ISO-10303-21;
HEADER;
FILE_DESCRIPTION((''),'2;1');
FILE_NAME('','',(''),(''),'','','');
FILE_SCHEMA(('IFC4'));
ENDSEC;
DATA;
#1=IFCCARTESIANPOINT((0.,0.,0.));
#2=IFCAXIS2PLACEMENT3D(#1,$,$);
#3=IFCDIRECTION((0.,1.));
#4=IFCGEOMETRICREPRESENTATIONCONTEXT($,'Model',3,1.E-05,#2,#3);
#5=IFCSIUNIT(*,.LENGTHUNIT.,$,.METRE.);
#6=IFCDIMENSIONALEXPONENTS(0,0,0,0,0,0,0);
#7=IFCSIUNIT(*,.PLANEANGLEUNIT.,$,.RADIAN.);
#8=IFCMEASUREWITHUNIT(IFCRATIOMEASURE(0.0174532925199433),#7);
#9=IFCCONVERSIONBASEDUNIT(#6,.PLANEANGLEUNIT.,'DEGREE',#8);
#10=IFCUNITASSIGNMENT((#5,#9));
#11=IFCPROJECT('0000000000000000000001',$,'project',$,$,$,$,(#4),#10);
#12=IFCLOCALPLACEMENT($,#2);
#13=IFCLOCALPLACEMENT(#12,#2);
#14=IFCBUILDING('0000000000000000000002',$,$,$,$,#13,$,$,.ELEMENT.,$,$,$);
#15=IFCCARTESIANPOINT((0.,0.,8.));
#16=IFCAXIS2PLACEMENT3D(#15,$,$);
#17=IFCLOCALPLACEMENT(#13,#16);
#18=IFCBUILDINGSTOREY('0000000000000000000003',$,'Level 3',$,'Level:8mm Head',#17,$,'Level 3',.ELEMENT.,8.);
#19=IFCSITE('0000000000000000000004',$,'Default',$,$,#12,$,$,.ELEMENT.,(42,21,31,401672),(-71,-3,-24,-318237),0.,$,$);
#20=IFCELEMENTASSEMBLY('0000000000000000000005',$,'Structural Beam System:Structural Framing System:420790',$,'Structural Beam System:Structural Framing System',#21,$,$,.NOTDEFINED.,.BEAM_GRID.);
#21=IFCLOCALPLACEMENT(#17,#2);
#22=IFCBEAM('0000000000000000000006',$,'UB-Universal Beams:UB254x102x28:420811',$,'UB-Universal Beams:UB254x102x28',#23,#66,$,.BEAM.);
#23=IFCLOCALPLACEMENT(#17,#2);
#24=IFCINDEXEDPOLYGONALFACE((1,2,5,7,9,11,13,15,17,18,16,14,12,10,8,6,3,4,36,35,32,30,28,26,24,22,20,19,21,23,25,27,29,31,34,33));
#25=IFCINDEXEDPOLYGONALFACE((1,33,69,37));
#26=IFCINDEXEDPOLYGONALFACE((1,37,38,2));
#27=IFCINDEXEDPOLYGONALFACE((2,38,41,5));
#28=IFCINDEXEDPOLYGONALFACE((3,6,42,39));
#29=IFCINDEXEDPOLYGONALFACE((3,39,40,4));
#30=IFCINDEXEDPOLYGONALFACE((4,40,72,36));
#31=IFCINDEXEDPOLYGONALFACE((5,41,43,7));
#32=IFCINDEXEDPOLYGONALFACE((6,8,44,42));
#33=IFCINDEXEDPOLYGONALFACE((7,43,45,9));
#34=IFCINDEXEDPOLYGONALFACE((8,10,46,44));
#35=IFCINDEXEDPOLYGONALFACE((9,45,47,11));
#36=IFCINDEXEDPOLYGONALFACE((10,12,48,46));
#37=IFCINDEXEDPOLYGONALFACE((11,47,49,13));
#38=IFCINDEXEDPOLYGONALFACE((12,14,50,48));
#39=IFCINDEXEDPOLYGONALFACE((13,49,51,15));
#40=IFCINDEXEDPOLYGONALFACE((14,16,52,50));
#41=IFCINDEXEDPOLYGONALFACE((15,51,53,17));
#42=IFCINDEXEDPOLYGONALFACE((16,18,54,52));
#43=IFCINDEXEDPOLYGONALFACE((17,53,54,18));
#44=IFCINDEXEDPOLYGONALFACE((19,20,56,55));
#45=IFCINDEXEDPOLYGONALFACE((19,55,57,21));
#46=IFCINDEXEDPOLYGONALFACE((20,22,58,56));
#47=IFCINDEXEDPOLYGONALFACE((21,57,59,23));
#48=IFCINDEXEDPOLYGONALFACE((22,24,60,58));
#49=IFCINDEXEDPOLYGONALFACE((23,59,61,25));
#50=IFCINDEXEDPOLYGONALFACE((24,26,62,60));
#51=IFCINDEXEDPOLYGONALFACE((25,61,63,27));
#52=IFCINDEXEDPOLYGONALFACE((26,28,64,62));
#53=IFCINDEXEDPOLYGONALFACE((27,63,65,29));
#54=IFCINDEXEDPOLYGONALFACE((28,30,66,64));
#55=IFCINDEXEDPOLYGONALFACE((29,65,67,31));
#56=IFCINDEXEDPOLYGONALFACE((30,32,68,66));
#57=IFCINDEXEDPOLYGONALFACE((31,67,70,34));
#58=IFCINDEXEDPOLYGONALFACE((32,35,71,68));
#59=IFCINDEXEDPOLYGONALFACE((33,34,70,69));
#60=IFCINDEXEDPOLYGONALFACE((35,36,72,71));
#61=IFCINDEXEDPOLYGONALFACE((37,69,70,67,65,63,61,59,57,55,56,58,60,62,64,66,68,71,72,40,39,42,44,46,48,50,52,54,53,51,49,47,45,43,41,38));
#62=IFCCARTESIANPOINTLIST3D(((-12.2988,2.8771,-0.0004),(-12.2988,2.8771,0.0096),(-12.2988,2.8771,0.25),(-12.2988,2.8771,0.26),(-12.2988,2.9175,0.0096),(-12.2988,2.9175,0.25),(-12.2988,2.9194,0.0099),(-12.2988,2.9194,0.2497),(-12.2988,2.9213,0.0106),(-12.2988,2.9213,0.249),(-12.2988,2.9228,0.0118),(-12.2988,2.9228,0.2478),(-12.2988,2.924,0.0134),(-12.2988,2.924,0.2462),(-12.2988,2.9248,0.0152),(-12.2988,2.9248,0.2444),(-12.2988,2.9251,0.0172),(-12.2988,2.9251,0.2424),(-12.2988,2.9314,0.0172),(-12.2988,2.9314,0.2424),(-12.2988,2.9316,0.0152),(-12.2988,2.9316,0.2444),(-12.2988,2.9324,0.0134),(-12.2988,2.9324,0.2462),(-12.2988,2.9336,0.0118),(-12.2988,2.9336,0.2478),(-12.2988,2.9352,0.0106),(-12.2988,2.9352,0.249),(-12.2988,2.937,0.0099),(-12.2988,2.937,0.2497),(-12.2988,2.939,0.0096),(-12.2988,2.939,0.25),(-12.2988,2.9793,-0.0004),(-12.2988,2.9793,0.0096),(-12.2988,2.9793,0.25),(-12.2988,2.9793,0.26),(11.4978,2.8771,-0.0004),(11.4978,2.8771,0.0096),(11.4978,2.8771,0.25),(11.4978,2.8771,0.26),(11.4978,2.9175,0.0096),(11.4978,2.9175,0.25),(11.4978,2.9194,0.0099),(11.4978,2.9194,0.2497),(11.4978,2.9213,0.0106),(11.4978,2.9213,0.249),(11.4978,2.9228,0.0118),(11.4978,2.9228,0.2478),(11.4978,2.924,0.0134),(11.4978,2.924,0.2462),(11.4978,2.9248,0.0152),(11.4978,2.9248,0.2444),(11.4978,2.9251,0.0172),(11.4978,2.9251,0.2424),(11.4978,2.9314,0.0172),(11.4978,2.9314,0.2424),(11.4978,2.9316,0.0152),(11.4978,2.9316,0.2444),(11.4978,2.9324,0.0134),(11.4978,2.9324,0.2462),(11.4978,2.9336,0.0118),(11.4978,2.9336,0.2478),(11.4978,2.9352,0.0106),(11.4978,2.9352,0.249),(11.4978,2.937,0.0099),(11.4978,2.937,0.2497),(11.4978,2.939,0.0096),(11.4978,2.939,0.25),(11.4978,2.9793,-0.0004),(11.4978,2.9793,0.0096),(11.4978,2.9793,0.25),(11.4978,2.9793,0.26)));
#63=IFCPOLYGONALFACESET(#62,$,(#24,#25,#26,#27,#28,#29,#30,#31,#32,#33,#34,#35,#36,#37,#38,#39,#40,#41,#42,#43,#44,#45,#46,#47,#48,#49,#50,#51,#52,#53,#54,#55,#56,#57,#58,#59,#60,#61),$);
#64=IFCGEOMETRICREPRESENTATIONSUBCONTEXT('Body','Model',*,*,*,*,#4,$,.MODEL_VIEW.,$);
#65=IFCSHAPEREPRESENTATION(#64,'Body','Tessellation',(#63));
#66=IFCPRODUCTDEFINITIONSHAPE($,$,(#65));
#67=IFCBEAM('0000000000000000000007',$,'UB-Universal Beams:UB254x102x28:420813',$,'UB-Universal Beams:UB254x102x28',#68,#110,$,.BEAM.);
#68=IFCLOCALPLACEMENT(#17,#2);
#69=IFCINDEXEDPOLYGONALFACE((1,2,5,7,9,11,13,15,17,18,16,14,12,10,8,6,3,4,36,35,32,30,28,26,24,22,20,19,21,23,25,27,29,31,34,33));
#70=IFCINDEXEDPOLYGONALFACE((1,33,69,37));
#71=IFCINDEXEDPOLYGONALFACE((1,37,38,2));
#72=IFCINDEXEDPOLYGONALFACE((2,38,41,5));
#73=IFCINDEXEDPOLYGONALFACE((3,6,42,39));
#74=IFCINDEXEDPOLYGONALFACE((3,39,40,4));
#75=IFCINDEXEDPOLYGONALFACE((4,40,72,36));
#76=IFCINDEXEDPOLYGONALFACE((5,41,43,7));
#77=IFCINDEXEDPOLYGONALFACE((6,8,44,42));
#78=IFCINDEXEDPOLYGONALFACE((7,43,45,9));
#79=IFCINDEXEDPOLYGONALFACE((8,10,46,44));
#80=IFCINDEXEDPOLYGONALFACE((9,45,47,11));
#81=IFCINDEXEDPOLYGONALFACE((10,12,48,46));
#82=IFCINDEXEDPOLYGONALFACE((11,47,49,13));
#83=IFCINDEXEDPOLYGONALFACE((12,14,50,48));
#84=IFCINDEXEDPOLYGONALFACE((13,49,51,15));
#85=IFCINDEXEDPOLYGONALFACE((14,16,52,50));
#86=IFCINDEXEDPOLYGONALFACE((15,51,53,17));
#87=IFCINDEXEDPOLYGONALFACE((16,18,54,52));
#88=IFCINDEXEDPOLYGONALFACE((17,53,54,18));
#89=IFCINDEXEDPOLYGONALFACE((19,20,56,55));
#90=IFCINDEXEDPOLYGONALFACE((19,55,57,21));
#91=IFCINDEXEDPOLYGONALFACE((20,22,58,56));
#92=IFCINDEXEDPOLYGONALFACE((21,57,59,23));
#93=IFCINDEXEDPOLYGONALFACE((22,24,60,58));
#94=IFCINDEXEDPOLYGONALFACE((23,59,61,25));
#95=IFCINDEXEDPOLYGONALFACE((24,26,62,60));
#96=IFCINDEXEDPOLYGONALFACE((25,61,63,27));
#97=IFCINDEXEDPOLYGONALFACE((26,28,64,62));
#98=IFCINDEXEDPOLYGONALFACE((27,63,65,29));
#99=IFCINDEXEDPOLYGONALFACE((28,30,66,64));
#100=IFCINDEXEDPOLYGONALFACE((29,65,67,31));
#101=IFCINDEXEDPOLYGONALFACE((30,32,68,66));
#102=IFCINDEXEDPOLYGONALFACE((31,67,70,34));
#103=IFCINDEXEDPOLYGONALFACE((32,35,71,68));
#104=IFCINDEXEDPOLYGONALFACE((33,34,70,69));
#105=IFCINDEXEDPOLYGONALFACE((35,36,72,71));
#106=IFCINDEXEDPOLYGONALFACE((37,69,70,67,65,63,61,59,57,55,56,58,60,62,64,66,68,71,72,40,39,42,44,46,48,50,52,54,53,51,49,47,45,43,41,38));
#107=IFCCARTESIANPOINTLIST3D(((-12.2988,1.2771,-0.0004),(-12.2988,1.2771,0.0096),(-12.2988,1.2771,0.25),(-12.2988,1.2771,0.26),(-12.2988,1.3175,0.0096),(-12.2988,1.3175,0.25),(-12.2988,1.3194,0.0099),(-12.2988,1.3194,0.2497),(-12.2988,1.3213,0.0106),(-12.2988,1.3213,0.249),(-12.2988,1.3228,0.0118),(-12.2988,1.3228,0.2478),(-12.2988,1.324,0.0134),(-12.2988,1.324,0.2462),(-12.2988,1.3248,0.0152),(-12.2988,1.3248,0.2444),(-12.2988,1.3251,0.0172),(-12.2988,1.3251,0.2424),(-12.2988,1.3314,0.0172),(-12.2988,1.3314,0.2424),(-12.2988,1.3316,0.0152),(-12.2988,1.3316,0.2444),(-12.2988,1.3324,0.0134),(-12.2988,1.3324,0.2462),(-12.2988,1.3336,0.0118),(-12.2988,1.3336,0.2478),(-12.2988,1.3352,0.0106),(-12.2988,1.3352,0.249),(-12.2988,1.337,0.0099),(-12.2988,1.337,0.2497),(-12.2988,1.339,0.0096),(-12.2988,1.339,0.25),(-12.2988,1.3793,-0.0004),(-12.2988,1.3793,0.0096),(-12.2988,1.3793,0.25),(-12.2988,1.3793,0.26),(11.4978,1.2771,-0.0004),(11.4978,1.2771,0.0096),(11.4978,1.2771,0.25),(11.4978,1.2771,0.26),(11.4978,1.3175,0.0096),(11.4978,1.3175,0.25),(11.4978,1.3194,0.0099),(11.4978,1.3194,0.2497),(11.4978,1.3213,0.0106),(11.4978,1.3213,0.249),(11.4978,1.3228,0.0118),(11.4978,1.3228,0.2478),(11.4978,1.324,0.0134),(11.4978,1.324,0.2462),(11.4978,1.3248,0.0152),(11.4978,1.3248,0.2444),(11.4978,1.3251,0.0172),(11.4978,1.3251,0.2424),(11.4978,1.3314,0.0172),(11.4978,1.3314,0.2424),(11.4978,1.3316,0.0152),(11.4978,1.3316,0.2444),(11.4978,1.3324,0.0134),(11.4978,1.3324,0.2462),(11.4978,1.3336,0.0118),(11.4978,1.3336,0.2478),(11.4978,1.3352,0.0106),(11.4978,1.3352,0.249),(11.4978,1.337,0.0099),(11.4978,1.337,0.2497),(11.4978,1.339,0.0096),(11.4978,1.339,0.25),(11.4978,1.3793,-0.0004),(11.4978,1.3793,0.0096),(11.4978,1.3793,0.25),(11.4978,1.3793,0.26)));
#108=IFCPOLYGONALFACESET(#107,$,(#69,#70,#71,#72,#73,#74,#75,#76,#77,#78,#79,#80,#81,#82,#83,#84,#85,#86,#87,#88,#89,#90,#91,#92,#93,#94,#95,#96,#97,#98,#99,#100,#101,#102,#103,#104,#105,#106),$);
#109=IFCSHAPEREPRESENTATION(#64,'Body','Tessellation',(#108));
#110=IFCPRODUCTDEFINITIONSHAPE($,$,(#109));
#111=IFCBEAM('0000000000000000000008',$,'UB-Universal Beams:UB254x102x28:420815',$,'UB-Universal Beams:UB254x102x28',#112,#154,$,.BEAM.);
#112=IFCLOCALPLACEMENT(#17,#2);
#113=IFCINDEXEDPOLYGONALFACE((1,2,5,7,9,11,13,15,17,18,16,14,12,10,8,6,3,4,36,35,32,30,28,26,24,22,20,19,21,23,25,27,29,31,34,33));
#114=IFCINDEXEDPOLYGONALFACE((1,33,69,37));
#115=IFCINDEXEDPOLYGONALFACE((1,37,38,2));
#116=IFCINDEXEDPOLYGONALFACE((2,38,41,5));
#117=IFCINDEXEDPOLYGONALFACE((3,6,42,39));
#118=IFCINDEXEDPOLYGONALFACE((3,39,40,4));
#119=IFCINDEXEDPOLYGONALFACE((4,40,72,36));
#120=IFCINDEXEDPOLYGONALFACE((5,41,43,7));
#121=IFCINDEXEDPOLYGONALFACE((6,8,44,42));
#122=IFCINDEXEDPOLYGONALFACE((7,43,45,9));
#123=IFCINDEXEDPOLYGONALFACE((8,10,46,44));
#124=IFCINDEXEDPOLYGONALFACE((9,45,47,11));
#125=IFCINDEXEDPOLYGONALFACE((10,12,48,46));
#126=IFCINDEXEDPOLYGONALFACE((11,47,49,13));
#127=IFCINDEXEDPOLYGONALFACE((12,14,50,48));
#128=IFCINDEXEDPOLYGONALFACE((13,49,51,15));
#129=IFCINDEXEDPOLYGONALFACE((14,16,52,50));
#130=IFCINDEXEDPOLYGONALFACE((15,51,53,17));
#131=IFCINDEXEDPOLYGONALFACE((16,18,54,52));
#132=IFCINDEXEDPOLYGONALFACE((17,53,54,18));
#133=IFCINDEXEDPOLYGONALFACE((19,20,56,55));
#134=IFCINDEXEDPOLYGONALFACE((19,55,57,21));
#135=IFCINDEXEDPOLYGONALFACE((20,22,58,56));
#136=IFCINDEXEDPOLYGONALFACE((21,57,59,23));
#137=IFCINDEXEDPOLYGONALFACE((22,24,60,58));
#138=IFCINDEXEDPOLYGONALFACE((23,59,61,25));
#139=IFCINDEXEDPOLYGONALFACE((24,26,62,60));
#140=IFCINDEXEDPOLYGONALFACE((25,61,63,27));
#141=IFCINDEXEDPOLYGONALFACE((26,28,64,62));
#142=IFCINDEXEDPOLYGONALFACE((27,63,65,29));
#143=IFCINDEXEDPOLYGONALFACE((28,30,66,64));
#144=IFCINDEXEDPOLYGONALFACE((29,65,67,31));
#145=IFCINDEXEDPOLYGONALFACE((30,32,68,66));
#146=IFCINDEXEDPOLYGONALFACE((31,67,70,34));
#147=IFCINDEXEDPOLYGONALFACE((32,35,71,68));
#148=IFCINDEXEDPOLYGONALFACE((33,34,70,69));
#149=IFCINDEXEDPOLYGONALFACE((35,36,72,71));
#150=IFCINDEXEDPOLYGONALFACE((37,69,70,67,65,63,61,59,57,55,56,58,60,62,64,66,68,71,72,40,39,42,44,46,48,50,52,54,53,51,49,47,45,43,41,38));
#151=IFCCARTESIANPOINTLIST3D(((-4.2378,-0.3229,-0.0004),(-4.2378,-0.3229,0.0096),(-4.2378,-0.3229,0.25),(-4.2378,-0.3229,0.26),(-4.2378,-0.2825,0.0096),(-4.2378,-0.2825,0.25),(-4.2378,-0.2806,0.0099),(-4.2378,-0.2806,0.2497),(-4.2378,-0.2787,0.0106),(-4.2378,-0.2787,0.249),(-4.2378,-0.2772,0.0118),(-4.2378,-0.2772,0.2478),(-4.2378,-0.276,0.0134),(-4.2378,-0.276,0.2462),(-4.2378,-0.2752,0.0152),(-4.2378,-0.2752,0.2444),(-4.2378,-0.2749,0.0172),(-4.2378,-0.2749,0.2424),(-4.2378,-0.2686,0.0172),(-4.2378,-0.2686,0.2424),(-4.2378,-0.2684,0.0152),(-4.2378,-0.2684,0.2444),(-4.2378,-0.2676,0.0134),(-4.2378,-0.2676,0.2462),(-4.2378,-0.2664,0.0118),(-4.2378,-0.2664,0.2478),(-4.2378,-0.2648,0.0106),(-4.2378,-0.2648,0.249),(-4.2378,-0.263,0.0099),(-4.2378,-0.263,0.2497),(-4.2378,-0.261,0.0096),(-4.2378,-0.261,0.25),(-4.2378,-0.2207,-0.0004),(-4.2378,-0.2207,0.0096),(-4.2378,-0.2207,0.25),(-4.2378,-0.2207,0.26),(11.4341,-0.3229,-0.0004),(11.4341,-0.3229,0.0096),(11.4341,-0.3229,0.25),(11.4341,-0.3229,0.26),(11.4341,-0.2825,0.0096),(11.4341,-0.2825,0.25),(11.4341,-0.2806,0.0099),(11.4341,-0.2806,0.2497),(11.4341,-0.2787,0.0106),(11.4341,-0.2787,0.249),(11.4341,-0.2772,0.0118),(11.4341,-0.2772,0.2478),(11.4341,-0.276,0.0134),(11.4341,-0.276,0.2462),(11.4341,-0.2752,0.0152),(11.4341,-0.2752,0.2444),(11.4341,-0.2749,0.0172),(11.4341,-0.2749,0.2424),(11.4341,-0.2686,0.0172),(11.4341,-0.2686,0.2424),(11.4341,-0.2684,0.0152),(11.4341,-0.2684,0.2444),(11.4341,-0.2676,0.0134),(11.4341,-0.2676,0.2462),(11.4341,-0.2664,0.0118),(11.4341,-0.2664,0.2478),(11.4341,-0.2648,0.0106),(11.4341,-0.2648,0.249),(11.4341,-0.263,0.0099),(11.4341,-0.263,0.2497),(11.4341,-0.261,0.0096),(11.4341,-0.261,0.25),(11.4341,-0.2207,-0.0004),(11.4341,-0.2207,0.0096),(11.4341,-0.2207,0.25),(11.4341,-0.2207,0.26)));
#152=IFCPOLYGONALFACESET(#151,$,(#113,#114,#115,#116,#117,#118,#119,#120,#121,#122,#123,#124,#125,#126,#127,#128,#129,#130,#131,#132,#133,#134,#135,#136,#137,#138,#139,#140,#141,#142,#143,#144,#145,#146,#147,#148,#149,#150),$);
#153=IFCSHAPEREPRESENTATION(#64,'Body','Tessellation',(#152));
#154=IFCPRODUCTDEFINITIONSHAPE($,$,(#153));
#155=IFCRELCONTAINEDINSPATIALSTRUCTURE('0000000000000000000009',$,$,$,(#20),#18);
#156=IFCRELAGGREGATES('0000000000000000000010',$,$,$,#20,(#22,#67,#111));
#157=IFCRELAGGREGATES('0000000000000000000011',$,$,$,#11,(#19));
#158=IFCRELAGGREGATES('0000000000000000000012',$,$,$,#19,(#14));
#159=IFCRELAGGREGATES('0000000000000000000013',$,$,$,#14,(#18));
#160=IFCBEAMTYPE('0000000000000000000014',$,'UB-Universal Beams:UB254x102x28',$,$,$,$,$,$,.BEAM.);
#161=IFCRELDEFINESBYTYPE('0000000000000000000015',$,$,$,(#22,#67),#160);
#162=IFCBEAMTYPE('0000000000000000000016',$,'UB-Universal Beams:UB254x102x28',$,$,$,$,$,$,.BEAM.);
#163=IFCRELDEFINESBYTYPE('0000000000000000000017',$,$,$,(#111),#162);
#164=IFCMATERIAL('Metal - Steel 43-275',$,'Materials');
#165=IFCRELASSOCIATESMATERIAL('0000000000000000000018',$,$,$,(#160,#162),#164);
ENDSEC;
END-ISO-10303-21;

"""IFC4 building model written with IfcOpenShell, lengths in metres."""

from ifc_helpers import new_model, entity, si_unit, converted_unit, direction, frame, frame_2d, origin, place, context, subcontext, project, spatial, i_section, extrude, source, transform, mapped, material, material_profile, profile_set, type_object, type_shapes, element, aggregate, save


model = new_model("IFC4")

# Units and contexts
model_context = context("Model", 3, precision=1e-05, world=origin(), true_north=direction((0.0, 1.0)))
body_context = subcontext(model_context, "Body", "Model", "MODEL_VIEW")
ifc_project = project(units=[si_unit("LENGTHUNIT", "METRE"), converted_unit("PLANEANGLEUNIT", "DEGREE", entity("IfcRatioMeasure", 0.0174532925199433), si_unit("PLANEANGLEUNIT", "RADIAN"), dimensions=[0, 0, 0, 0, 0, 0, 0])], contexts=[model_context])

# Site, building, storey
site_placement = place(None, origin())
site = spatial("IfcSite", under=ifc_project, at=site_placement, Name="Default", CompositionType="ELEMENT", RefLatitude=(42, 21, 31, 401672), RefLongitude=(-71, -3, -24, -318237), RefElevation=0.0)
building_placement = place(site_placement, origin())
building = spatial("IfcBuilding", under=site, at=building_placement, CompositionType="ELEMENT")
storey_placement = place(building_placement, frame((0.0, 0.0, 8.0)))
storey = spatial("IfcBuildingStorey", under=building, at=storey_placement, Name="Level 3", ObjectType="Level:8mm Head", LongName="Level 3", CompositionType="ELEMENT", Elevation=8.0)

# Shared definitions
ifc_material_1 = material(Name="Metal - Steel 43-275", Category="Materials")

# Element assembly, beams
assembly_placement = place(storey_placement, origin())
assembly = element("IfcElementAssembly", 1, at=assembly_placement, inside=storey, Name="Structural Beam System:Structural Framing System:420790", ObjectType="Structural Beam System:Structural Framing System", AssemblyPlace="NOTDEFINED", PredefinedType="BEAM_GRID")
ifc_material_profile_1 = material_profile(ifc_material_1, i_section(OverallWidth=0.1022, OverallDepth=0.2604, WebThickness=0.0063, FlangeThickness=0.01, FilletRadius=0.0076, at=frame_2d((0.0, 0.0), x_axis=(0.0, 1.0))), Name="UB254x102x28")
ifc_profile_set_1 = profile_set([ifc_material_profile_1], Name="UB254x102x28")
beam_type_1 = type_object("IfcBeamType", Name="UB-Universal Beams:UB254x102x28", PredefinedType="BEAM", material=ifc_profile_set_1)
shared_shape_1 = source(origin(), body_context, "Body", "SweptSolid", [
    extrude(i_section(OverallWidth=0.1022, OverallDepth=0.2604, WebThickness=0.0063, FlangeThickness=0.01, FilletRadius=0.0076, at=frame_2d((0.0, 0.0), x_axis=(0.0, 1.0))), frame((-11.8983, 0.0, 0.0), z_axis=(1.0, 0.0, 0.0), x_axis=(0.0, 0.0, -1.0)), (0.0, 0.0, 1.0), 23.7966),
])
type_shapes(beam_type_1, [shared_shape_1])
beam_1_placement = place(assembly_placement, frame((-0.4005, 2.9282, 0.1298)))
beam_1 = element("IfcBeam", 2, at=beam_1_placement, type_object=beam_type_1, Name="UB-Universal Beams:UB254x102x28:420811", ObjectType="UB-Universal Beams:UB254x102x28", PredefinedType="BEAM", context=body_context, shape_type="MappedRepresentation", body=[
    mapped(shared_shape_1, transform((0.0, 0.0, 0.0), scale=1.0)),
])
beam_2_placement = place(assembly_placement, frame((-0.4005, 1.3282, 0.1298)))
beam_2 = element("IfcBeam", 3, at=beam_2_placement, type_object=beam_type_1, Name="UB-Universal Beams:UB254x102x28:420813", ObjectType="UB-Universal Beams:UB254x102x28", PredefinedType="BEAM", context=body_context, shape_type="MappedRepresentation", body=[
    mapped(shared_shape_1, transform((0.0, 0.0, 0.0), scale=1.0)),
])
beam_type_2 = type_object("IfcBeamType", Name="UB-Universal Beams:UB254x102x28", PredefinedType="BEAM", material=ifc_profile_set_1)
shared_shape_2 = source(origin(), body_context, "Body", "SweptSolid", [
    extrude(i_section(OverallWidth=0.1022, OverallDepth=0.2604, WebThickness=0.0063, FlangeThickness=0.01, FilletRadius=0.0076, at=frame_2d((0.0, 0.0), x_axis=(0.0, 1.0))), frame((-7.8818, 0.0, 0.0), z_axis=(1.0, 0.0, 0.0), x_axis=(0.0, 0.0, -1.0)), (0.0, 0.0, 1.0), 15.6719),
])
type_shapes(beam_type_2, [shared_shape_2])
beam_3_placement = place(assembly_placement, frame((3.644, -0.2718, 0.1298)))
beam_3 = element("IfcBeam", 4, at=beam_3_placement, type_object=beam_type_2, Name="UB-Universal Beams:UB254x102x28:420815", ObjectType="UB-Universal Beams:UB254x102x28", PredefinedType="BEAM", context=body_context, shape_type="MappedRepresentation", body=[
    mapped(shared_shape_2, transform((0.0, 0.0, 0.0), scale=1.0)),
])
aggregate(assembly, [beam_1, beam_2, beam_3])

save(model, "model.ifc")
